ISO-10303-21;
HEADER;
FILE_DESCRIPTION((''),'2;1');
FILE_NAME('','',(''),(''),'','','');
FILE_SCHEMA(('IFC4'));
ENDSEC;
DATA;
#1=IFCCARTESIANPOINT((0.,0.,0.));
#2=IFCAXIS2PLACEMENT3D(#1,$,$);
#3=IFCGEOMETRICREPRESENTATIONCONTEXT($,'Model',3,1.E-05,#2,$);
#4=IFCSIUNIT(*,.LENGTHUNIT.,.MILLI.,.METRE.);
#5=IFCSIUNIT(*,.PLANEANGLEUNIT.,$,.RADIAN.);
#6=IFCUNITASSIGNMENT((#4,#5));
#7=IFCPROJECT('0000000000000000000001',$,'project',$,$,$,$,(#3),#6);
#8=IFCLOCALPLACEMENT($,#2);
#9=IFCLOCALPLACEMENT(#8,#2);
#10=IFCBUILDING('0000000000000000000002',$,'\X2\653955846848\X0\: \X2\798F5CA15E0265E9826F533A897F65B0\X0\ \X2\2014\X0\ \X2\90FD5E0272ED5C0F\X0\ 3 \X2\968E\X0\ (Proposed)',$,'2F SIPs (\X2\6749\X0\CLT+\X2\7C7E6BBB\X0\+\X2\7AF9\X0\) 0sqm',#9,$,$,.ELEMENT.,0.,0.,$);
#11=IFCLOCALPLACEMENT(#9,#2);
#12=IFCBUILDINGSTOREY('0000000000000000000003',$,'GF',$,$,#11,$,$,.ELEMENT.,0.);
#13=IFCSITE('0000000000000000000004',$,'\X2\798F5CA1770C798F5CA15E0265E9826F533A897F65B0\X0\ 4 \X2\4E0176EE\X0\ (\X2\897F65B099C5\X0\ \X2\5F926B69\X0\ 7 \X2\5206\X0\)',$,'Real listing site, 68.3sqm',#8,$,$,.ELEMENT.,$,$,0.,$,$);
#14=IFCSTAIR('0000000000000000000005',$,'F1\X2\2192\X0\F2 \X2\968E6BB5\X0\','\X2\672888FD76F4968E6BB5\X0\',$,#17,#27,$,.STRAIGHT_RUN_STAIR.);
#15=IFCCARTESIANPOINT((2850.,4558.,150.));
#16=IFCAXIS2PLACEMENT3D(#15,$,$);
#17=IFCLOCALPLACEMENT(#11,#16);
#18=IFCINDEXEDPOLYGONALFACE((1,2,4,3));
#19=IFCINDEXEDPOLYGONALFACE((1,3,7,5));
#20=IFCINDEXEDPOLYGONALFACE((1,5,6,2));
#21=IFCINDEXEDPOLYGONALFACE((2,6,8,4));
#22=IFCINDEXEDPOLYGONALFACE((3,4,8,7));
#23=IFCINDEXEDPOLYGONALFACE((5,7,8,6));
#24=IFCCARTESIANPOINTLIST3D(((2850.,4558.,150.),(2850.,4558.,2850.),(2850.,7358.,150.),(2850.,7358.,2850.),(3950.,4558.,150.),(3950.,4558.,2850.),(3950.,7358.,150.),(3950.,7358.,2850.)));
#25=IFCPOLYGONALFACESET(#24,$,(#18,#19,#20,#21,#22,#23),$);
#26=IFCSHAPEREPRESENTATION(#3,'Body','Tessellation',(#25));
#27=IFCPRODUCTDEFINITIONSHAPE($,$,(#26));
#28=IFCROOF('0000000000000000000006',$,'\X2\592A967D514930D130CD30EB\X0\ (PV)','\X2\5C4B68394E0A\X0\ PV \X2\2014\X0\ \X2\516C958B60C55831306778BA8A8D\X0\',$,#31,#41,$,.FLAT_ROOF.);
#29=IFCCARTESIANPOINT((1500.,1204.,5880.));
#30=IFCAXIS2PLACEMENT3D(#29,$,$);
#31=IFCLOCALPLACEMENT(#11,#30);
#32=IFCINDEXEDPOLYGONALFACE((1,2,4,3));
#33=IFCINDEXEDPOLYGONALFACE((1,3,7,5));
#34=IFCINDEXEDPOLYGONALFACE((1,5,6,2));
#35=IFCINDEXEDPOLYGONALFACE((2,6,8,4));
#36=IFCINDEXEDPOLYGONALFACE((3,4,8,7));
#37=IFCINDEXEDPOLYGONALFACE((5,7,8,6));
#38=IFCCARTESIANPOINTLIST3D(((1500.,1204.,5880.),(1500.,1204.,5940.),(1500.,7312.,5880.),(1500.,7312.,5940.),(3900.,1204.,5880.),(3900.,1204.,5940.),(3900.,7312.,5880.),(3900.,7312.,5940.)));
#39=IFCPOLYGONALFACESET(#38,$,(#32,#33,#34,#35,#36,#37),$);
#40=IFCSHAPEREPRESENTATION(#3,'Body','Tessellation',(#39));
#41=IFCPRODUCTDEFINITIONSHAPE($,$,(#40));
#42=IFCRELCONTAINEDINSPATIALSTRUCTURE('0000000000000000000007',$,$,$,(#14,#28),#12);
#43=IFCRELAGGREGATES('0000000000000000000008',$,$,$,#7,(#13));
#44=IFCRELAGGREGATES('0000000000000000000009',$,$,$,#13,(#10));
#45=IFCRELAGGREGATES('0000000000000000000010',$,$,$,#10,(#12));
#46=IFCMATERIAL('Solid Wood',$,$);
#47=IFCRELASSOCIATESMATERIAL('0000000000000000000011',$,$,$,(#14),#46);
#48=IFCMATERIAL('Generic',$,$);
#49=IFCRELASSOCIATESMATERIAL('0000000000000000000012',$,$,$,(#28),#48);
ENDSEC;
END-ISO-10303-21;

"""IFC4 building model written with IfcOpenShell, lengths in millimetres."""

from ifc_helpers import new_model, si_unit, frame, frame_2d, origin, place, context, project, spatial, rectangle, extrude, material, element, save


model = new_model("IFC4")

# Units and contexts
model_context = context("Model", 3, precision=1e-05, world=origin())
ifc_project = project(units=[si_unit("LENGTHUNIT", "METRE", prefix="MILLI"), si_unit("PLANEANGLEUNIT", "RADIAN")], contexts=[model_context])

# Site, building, storey
site_placement = place(None, origin())
site = spatial("IfcSite", under=ifc_project, at=site_placement, Name="福岡県福岡市早良区西新 4 丁目 (西新駅 徒歩 7 分)", ObjectType="Real listing site, 68.3sqm", CompositionType="ELEMENT", RefElevation=0.0)
building_placement = place(site_placement, origin())
building = spatial("IfcBuilding", under=site, at=building_placement, Name="改善案: 福岡市早良区西新 — 都市狭小 3 階 (Proposed)", ObjectType="2F SIPs (杉CLT+籾殻+竹) 0sqm", CompositionType="ELEMENT", ElevationOfRefHeight=0.0, ElevationOfTerrain=0.0)
storey_placement = place(building_placement, origin())
storey = spatial("IfcBuildingStorey", under=building, at=storey_placement, Name="GF", CompositionType="ELEMENT", Elevation=0.0)

# Shared definitions
ifc_material_1 = material(Name="Generic")

# Stair
ifc_material_2 = material(Name="Solid Wood")
stair_placement = place(storey_placement, frame((2850.0, 4558.0, 150.0)))
element("IfcStair", 1, at=stair_placement, inside=storey, material=ifc_material_2, Name="F1→F2 階段", Description="木製直階段", PredefinedType="STRAIGHT_RUN_STAIR", context=model_context, shape_type="SweptSolid", body=[
    extrude(rectangle(XDim=1100.0, YDim=2800.0, at=frame_2d((550.0, 1400.0))), frame((2850.0, 4558.0, 150.0)), (0.0, 0.0, 1.0), 2700.0),
])

# Roof
roof_placement = place(storey_placement, frame((1500.0, 1204.0, 5880.0)))
element("IfcRoof", 2, at=roof_placement, inside=storey, material=ifc_material_1, Name="太陽光パネル (PV)", Description="屋根上 PV — 公開情報で確認", PredefinedType="FLAT_ROOF", context=model_context, shape_type="SweptSolid", body=[
    extrude(rectangle(XDim=2400.0, YDim=6108.0, at=frame_2d((1200.0, 3054.0))), frame((1500.0, 1204.0, 5880.0)), (0.0, 0.0, 1.0), 60.0),
])

save(model, "model.ifc")
